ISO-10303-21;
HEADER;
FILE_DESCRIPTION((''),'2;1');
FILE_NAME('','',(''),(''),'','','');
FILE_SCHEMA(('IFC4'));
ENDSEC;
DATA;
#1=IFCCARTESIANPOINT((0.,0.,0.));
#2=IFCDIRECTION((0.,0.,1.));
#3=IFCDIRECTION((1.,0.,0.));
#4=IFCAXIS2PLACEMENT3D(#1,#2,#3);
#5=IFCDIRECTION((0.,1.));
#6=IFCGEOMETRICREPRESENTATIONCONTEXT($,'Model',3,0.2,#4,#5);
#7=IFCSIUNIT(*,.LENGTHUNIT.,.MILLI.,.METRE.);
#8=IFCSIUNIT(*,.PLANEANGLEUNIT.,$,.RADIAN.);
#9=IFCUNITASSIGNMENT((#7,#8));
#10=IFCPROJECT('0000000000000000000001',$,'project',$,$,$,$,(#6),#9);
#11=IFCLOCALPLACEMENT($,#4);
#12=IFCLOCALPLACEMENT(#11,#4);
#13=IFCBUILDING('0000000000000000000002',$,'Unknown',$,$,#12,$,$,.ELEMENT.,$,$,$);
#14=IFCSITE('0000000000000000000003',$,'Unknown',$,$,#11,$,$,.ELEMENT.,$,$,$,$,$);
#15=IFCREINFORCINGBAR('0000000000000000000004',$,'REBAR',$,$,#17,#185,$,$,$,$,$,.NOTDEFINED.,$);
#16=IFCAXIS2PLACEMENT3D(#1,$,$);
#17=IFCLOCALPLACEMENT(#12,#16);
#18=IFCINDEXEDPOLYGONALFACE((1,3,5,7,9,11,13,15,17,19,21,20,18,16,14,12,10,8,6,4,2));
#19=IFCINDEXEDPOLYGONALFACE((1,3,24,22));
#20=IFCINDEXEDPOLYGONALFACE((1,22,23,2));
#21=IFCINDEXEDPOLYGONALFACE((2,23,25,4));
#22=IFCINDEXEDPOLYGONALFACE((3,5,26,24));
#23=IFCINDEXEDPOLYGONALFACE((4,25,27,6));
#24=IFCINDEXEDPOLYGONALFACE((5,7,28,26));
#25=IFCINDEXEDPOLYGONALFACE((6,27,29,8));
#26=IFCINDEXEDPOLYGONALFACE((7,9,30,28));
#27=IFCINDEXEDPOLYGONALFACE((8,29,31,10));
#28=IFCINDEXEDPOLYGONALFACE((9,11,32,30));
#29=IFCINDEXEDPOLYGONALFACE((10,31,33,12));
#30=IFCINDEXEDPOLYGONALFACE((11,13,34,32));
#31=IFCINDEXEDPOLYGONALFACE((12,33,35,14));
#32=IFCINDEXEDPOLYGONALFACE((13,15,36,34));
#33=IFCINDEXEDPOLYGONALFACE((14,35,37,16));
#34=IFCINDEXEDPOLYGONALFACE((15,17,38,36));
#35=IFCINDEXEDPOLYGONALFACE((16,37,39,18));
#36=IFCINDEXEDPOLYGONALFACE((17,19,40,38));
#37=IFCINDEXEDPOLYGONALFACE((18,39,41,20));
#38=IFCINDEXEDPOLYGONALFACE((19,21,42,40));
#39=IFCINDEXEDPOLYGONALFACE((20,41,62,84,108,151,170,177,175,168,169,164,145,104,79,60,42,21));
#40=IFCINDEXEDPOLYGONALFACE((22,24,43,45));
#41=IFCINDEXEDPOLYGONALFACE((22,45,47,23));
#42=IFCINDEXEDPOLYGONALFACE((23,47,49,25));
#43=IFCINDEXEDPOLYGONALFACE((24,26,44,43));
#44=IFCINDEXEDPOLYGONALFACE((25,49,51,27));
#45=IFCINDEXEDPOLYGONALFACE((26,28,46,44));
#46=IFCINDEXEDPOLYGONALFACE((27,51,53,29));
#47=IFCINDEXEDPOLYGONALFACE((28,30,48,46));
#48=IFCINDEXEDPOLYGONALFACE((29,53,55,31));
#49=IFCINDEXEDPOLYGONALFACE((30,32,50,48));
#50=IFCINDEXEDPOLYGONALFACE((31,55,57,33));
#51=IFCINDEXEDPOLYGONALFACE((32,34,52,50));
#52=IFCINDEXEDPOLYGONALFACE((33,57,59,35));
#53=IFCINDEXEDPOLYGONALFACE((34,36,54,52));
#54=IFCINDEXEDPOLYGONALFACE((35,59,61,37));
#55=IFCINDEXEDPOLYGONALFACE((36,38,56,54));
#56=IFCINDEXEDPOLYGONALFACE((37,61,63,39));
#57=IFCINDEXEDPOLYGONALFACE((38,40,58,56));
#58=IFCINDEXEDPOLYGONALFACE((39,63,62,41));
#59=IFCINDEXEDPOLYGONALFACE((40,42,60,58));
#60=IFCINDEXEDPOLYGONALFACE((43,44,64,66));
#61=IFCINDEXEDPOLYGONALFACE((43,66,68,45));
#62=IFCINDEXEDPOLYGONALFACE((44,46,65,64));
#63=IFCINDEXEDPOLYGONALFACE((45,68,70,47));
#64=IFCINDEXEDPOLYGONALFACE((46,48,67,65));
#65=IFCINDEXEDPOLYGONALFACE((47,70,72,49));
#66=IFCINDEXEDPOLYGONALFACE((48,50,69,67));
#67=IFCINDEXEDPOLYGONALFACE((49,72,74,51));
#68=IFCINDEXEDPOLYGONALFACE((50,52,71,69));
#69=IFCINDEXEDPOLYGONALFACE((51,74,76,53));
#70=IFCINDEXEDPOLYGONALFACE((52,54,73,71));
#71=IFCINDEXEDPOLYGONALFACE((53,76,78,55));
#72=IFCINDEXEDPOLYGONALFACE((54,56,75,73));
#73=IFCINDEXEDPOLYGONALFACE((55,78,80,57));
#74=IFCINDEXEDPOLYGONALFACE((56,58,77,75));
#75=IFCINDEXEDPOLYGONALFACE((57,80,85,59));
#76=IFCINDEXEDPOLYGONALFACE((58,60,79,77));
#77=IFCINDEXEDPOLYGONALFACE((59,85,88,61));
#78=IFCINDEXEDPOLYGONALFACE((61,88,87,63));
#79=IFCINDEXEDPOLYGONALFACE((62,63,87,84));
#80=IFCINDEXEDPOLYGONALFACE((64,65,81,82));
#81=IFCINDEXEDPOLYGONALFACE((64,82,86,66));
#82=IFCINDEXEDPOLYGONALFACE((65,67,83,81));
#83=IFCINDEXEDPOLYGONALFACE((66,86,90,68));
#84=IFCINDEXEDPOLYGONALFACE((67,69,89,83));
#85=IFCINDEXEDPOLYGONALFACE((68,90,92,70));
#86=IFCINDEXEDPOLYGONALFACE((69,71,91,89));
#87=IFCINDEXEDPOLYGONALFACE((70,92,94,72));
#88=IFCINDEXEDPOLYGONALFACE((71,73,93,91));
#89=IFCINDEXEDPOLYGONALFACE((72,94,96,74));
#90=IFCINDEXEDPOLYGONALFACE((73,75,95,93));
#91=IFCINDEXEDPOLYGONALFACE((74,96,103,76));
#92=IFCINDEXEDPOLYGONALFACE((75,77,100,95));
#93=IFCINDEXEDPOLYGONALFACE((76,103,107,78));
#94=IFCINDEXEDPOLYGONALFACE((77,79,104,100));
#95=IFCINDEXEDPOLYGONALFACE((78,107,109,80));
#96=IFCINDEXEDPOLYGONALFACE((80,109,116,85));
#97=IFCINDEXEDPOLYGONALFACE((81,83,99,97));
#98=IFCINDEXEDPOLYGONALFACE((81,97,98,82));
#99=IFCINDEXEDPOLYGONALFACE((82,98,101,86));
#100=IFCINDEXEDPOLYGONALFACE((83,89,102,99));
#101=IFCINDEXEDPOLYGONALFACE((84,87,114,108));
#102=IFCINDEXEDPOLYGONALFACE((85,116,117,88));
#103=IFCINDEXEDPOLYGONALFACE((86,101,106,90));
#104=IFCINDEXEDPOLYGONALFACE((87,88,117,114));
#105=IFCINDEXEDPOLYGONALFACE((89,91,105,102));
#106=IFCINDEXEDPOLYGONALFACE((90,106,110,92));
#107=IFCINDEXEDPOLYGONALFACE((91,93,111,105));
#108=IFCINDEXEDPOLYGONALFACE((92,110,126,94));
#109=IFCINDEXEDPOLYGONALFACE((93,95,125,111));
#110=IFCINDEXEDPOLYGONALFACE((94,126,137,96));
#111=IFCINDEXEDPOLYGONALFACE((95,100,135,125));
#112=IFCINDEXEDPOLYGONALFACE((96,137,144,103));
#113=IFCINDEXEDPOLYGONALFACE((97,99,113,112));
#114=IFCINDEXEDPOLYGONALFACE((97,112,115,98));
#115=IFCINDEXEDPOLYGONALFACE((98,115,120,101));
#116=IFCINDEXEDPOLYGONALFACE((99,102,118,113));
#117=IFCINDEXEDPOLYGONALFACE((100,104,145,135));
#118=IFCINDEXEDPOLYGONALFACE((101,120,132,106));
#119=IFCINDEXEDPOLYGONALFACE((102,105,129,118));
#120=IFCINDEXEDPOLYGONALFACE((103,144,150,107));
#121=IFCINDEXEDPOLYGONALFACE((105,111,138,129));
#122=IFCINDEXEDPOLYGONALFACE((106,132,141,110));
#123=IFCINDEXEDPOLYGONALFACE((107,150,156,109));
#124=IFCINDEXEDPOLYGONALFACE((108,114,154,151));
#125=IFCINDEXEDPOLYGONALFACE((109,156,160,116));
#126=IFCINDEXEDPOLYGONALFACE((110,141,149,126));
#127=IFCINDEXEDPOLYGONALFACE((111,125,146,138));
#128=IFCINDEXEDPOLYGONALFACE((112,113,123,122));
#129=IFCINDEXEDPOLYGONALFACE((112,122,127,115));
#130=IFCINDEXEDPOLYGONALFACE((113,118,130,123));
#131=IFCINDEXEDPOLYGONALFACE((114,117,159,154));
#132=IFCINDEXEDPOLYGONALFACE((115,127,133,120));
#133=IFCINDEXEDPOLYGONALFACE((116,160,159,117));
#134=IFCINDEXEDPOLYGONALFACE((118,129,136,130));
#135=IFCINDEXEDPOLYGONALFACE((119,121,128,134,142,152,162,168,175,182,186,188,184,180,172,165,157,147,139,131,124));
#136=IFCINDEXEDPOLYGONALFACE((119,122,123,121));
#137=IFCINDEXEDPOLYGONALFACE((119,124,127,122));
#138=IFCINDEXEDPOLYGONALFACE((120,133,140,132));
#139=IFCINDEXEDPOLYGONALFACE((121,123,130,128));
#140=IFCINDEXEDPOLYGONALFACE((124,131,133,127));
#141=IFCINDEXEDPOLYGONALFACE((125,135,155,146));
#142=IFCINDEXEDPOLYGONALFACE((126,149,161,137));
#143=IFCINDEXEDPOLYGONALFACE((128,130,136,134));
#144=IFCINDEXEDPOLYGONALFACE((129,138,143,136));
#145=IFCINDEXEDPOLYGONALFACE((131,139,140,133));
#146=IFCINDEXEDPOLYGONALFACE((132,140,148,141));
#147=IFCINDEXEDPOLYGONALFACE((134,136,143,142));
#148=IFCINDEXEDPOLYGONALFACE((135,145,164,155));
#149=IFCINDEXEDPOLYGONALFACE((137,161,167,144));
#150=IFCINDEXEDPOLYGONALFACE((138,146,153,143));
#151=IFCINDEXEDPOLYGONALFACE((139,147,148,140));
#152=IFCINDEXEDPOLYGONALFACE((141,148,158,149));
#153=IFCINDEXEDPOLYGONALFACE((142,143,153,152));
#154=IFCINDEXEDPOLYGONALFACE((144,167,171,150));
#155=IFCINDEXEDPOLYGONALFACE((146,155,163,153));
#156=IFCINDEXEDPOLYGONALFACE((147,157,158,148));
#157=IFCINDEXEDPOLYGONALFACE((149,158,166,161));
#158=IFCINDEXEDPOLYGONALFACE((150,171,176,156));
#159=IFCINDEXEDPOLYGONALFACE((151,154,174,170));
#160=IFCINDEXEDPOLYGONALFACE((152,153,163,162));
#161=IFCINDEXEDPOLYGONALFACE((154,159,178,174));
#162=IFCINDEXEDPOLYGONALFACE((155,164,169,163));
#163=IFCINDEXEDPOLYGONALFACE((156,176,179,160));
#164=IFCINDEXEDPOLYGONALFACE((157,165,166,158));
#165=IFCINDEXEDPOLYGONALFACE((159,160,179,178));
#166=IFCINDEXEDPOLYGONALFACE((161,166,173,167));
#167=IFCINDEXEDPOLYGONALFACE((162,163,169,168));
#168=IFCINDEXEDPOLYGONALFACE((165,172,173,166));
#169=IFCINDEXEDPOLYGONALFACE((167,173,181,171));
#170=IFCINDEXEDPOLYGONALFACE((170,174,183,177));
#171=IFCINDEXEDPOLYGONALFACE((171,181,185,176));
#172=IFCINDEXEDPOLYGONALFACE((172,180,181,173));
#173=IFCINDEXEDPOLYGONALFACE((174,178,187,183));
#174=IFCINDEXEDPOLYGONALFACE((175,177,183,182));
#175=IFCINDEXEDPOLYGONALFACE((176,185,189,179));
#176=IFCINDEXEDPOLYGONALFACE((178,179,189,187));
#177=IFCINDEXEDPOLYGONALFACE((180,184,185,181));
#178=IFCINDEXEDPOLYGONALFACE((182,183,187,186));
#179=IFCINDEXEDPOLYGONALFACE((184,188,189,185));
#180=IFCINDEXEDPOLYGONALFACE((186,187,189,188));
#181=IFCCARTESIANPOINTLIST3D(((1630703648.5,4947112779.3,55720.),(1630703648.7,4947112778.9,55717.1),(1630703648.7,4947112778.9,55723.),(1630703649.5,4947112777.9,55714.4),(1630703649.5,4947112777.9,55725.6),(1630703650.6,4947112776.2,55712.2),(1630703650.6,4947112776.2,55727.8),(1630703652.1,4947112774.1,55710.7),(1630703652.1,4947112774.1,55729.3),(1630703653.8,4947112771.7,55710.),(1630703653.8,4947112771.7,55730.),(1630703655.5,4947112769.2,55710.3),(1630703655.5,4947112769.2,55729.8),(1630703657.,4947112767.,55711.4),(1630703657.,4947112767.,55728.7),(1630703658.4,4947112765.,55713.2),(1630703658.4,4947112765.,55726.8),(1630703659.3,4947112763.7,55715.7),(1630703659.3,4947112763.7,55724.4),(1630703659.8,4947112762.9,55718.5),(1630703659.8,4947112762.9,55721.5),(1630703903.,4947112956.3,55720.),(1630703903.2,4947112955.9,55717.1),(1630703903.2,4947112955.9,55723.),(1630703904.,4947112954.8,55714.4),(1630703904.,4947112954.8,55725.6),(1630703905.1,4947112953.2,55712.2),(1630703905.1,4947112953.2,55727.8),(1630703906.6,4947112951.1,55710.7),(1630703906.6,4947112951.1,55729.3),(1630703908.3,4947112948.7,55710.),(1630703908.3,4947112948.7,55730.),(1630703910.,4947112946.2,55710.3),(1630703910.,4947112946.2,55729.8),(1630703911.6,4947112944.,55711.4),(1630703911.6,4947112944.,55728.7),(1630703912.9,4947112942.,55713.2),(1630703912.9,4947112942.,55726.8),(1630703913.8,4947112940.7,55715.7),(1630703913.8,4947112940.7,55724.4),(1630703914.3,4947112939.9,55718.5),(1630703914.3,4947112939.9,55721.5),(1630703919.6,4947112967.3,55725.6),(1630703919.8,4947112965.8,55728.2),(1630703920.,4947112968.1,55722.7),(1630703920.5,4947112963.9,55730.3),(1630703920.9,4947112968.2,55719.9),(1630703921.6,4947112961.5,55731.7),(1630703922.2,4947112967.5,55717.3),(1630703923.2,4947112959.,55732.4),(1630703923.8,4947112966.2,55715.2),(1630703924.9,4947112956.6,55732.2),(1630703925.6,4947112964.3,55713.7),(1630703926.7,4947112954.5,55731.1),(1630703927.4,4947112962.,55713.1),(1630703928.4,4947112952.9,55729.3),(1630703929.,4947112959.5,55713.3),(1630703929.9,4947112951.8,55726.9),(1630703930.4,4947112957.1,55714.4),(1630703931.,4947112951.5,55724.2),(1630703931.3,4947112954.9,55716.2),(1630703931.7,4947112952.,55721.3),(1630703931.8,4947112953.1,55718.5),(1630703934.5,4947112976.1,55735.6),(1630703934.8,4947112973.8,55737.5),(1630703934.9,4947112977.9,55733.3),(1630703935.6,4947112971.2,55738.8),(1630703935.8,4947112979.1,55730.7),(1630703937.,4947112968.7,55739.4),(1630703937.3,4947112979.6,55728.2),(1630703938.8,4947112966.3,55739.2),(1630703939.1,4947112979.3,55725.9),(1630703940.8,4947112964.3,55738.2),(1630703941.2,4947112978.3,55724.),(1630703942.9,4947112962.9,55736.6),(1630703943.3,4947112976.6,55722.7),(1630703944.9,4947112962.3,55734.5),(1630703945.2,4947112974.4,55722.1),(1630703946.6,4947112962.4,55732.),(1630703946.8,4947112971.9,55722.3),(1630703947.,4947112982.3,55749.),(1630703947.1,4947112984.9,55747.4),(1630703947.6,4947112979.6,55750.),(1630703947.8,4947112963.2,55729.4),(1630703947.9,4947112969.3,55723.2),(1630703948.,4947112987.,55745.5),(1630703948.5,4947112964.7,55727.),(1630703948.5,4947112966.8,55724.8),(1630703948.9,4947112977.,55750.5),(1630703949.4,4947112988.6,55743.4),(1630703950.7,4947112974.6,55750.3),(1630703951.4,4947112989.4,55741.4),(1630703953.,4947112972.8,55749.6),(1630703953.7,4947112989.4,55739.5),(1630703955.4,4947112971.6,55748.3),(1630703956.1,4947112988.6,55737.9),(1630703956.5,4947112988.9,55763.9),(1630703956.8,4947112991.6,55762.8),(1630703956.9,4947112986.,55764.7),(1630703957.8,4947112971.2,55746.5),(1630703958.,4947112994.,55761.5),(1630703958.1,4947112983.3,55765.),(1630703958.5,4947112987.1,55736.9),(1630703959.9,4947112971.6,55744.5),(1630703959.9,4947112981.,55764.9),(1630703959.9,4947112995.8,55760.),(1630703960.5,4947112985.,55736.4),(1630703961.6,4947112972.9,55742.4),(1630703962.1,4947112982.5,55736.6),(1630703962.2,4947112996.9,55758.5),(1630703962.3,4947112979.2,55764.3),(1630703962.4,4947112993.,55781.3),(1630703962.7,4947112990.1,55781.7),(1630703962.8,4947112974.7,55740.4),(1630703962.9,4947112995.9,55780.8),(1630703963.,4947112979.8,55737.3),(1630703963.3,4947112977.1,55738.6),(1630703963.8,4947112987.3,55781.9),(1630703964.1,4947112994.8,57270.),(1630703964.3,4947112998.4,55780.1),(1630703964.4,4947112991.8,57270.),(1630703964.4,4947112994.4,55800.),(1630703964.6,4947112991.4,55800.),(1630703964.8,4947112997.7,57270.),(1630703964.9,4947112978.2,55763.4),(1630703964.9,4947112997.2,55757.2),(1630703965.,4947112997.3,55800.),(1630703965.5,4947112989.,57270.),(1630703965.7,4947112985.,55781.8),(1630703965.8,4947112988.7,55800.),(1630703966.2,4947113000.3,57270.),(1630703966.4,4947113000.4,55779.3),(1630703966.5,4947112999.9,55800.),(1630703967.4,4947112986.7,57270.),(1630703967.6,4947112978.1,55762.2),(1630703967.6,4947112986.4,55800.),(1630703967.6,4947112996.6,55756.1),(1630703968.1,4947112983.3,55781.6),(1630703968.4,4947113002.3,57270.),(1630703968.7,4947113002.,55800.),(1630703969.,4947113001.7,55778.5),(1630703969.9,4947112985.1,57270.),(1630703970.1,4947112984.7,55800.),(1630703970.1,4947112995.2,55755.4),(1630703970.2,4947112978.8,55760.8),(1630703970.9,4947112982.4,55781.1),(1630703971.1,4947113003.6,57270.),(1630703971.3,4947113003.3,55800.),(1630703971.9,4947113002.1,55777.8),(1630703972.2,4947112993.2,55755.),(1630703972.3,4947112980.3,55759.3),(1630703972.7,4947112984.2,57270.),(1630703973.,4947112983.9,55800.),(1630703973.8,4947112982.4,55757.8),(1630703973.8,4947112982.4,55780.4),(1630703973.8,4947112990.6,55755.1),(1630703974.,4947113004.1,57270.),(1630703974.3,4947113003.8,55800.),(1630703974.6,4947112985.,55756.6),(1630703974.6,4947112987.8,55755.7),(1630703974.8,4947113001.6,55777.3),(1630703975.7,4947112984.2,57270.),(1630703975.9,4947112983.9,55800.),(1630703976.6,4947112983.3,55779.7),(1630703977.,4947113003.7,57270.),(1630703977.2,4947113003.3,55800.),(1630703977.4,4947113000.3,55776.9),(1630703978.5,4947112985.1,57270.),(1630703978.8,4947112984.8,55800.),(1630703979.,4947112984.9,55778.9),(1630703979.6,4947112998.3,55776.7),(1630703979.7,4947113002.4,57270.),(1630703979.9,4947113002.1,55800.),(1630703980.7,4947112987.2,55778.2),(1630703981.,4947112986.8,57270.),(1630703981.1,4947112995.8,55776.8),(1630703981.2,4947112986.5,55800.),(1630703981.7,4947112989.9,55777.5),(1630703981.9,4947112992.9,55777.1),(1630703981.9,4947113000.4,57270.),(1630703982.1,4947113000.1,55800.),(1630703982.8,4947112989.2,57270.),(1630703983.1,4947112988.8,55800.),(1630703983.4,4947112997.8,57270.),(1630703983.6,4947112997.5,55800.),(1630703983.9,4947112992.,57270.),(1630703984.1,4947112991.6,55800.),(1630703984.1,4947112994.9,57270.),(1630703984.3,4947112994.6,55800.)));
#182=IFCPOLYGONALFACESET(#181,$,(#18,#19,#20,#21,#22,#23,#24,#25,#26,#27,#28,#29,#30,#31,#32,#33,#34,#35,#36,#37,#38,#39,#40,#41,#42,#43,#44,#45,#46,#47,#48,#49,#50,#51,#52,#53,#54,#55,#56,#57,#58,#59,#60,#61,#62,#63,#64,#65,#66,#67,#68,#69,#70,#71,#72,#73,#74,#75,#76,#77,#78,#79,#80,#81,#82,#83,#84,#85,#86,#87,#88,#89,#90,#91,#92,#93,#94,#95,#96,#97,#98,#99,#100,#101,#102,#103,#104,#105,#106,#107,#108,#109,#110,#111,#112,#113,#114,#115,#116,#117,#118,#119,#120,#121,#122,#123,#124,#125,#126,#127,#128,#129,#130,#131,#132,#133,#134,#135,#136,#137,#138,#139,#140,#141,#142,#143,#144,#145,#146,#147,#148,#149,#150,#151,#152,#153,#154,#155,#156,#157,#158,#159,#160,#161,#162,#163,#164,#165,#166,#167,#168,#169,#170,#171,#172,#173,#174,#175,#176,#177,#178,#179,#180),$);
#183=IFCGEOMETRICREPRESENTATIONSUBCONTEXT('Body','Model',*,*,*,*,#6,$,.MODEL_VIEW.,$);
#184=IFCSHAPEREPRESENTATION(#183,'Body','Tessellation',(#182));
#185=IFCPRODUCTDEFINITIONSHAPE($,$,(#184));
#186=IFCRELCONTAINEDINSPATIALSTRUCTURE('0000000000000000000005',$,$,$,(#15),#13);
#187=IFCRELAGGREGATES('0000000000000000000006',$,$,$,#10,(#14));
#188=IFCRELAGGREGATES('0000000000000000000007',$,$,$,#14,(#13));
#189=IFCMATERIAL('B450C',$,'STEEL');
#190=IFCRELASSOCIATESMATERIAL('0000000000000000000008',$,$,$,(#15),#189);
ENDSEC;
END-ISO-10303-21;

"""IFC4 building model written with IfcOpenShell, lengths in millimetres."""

from ifc_helpers import new_model, entity, si_unit, direction, frame, origin_with_axes, place, context, subcontext, project, spatial, material, element, save


model = new_model("IFC4")

# Units and contexts
model_context = context("Model", 3, precision=0.2, world=origin_with_axes(), true_north=direction((0.0, 1.0)))
body_context = subcontext(model_context, "Body", "Model", "MODEL_VIEW")
ifc_project = project(units=[si_unit("LENGTHUNIT", "METRE", prefix="MILLI"), si_unit("PLANEANGLEUNIT", "RADIAN")], contexts=[model_context])

# Site, building
site_placement = place(None, origin_with_axes())
site = spatial("IfcSite", under=ifc_project, at=site_placement, Name="Unknown", CompositionType="ELEMENT")
building_placement = place(site_placement, origin_with_axes())
building = spatial("IfcBuilding", under=site, at=building_placement, Name="Unknown", CompositionType="ELEMENT")

# Reinforcing bar
ifc_material = material(Name="B450C", Category="STEEL")
reinforcing_bar_1_placement = place(building_placement, frame((1630703986.9, 4947113063.3, 55670.0), z_axis=(0.570957, -0.82098, 0.0), x_axis=(0.0, 0.0, 1.0)))
element("IfcReinforcingBar", 1, at=reinforcing_bar_1_placement, inside=building, material=ifc_material, Name="REBAR", PredefinedType="NOTDEFINED", context=body_context, shape_type="AdvancedSweptSolid", body=[
    entity("IfcSweptDiskSolid", entity("IfcIndexedPolyCurve", entity("IfcCartesianPointList3D", [[50.0, 440.0, 50.0], [50.0, 130.0, 50.0], [73.4, 73.4, 50.0], [130.0, 50.0, 50.0], [1600.0, 50.0, 49.5]]), [entity("IfcLineIndex", [1, 2]), entity("IfcArcIndex", [2, 3, 4]), entity("IfcLineIndex", [4, 5])]), 10.0),
])

save(model, "model.ifc")
